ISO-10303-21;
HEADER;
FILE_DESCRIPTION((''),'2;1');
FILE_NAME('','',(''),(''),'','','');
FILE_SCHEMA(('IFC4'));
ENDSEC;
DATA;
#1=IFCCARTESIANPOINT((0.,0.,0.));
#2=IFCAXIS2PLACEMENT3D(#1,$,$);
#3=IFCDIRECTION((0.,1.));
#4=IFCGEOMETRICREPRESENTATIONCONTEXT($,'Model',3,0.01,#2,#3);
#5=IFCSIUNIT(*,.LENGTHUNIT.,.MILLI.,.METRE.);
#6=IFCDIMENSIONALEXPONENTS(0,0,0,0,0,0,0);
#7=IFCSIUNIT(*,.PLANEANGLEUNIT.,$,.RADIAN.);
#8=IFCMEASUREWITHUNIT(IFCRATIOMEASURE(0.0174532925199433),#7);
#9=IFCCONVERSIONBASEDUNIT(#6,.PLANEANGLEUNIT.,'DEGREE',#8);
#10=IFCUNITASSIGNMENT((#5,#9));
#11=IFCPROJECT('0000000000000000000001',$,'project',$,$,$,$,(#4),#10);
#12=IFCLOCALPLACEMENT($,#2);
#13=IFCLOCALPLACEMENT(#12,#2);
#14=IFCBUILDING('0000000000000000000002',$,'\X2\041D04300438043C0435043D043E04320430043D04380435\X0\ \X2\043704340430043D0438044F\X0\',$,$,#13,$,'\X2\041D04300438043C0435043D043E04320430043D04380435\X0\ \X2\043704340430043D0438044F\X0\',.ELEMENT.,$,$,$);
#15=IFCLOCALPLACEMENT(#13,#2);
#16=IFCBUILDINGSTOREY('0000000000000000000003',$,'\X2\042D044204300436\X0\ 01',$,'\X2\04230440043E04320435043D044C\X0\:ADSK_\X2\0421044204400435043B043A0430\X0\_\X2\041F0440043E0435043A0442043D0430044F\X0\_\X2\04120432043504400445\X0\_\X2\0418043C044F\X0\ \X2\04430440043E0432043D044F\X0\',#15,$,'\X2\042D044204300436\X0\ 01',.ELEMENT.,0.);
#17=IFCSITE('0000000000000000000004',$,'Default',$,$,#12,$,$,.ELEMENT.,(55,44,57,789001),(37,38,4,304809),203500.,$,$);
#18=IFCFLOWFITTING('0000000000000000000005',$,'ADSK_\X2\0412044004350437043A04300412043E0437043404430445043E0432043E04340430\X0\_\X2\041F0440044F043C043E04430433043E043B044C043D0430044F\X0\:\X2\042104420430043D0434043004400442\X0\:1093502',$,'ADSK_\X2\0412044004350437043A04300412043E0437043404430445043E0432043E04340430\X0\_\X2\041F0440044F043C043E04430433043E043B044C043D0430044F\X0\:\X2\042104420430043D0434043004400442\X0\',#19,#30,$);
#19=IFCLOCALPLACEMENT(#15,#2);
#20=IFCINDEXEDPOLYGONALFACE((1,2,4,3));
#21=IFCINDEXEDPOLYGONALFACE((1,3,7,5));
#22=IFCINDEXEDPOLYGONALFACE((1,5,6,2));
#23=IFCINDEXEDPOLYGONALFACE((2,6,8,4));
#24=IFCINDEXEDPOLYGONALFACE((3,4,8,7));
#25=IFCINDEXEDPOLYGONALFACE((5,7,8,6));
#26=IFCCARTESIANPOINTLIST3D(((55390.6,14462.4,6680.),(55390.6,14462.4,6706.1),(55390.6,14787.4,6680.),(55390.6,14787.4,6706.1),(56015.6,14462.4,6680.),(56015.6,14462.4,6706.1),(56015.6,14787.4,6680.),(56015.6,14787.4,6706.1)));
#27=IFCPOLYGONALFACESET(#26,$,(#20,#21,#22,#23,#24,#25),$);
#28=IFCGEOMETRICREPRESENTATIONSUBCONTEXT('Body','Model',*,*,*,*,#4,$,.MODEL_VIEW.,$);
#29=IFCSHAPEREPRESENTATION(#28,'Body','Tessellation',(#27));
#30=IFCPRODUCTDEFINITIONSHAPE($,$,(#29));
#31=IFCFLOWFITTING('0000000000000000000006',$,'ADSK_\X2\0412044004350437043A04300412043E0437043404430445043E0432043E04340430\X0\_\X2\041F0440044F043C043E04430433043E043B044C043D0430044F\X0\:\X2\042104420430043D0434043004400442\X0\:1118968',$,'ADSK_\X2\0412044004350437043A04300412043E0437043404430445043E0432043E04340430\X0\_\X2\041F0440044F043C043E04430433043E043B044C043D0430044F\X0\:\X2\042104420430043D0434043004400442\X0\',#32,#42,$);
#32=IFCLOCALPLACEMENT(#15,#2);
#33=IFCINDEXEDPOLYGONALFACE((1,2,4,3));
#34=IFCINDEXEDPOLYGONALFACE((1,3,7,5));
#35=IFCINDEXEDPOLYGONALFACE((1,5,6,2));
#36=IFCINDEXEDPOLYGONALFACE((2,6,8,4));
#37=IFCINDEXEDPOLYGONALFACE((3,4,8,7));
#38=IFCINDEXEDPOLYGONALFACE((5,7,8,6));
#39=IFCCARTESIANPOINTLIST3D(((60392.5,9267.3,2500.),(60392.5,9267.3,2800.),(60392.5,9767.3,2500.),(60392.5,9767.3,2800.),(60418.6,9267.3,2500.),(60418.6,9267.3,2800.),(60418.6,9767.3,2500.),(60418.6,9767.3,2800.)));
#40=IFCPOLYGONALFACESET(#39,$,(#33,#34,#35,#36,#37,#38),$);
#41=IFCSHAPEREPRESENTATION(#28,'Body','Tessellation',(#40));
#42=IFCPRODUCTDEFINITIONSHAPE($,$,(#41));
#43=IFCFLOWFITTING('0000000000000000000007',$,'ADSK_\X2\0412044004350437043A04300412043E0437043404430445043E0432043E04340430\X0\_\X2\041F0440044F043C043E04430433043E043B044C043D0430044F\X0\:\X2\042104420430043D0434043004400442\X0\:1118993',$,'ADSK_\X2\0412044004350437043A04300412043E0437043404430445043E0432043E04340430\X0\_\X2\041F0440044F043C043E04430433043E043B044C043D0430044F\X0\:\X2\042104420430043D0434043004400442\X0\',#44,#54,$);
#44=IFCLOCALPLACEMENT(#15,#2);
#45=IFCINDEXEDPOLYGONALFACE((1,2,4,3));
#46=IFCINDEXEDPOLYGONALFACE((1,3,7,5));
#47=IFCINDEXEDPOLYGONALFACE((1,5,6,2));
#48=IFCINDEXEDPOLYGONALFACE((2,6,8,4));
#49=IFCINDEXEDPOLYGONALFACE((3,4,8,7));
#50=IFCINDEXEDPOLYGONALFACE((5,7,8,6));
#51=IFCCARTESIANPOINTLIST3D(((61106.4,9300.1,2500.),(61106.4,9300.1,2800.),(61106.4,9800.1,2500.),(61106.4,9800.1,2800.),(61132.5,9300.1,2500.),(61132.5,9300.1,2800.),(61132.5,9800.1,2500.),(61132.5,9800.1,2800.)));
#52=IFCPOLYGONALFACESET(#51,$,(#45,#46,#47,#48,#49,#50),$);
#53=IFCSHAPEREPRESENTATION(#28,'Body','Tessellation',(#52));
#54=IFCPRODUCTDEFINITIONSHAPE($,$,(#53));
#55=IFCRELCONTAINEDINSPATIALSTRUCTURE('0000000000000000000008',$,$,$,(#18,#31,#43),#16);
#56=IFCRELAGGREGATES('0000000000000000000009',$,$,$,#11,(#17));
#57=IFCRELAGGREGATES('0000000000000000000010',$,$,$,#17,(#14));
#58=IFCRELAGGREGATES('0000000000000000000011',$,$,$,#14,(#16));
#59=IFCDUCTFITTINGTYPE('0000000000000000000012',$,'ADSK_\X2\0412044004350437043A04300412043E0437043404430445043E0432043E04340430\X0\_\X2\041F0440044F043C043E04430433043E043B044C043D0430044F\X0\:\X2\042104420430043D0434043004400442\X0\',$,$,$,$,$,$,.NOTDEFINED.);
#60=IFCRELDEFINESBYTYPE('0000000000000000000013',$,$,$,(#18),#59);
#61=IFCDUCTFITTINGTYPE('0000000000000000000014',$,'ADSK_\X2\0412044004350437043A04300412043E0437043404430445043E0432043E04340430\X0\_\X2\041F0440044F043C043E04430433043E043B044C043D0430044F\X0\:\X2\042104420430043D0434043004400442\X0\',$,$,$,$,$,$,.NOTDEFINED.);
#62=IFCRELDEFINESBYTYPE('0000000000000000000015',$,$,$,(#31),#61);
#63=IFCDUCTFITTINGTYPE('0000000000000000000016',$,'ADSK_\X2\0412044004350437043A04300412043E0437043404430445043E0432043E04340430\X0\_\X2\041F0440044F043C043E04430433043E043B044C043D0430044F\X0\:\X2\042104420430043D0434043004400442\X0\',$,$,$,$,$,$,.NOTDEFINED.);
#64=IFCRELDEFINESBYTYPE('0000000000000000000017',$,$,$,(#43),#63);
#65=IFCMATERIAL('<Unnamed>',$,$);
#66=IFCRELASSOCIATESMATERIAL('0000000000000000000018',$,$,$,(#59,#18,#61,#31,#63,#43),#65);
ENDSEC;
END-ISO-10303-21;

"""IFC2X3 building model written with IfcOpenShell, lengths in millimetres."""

from ifc_helpers import new_model, entity, si_unit, converted_unit, direction, frame, origin, origin_2d_with_axis, place, context, subcontext, project, spatial, rectangle, extrude, source, transform, mapped, material, type_object, type_shapes, element, save


model = new_model("IFC2X3")

# Units and contexts
model_context = context("Model", 3, precision=0.01, world=origin(), true_north=direction((0.0, 1.0)))
body_context = subcontext(model_context, "Body", "Model", "MODEL_VIEW")
ifc_project = project(units=[si_unit("LENGTHUNIT", "METRE", prefix="MILLI"), converted_unit("PLANEANGLEUNIT", "DEGREE", entity("IfcRatioMeasure", 0.0174532925199433), si_unit("PLANEANGLEUNIT", "RADIAN"), dimensions=[0, 0, 0, 0, 0, 0, 0])], contexts=[model_context])

# Site, building, storey
site_placement = place(None, origin())
site = spatial("IfcSite", under=ifc_project, at=site_placement, Name="Default", CompositionType="ELEMENT", RefLatitude=(55, 44, 57, 789001), RefLongitude=(37, 38, 4, 304809), RefElevation=203500.0)
building_placement = place(site_placement, origin())
building = spatial("IfcBuilding", under=site, at=building_placement, Name="Наименование здания", LongName="Наименование здания", CompositionType="ELEMENT")
storey_placement = place(building_placement, origin())
storey = spatial("IfcBuildingStorey", under=building, at=storey_placement, Name="Этаж 01", ObjectType="Уровень:ADSK_Стрелка_Проектная_Вверх_Имя уровня", LongName="Этаж 01", CompositionType="ELEMENT", Elevation=0.0)

# Shared definitions
ifc_material_1 = material(Name="<Unnamed>")

# Flow fittings
duct_fitting_type_1 = type_object("IfcDuctFittingType", Name="ADSK_ВрезкаВоздуховода_Прямоугольная:Стандарт", PredefinedType="NOTDEFINED", material=ifc_material_1)
shared_shape_1 = source(origin(), body_context, "Body", "SweptSolid", [
    extrude(rectangle(XDim=625.0, YDim=26.1, at=origin_2d_with_axis()), frame((7.0, 0.0, -162.5), z_axis=(0.0, 0.0, 1.0), x_axis=(0.0, -1.0, 0.0)), (0.0, 0.0, 1.0), 325.0),
])
type_shapes(duct_fitting_type_1, [shared_shape_1])
flow_fitting_1_placement = place(storey_placement, frame((55703.1, 14624.9, 6700.0), z_axis=(0.0, -1.0, 0.0), x_axis=(0.0, 0.0, -1.0)))
element("IfcFlowFitting", 1, at=flow_fitting_1_placement, inside=storey, type_object=duct_fitting_type_1, material=ifc_material_1, Name="ADSK_ВрезкаВоздуховода_Прямоугольная:Стандарт:1093502", ObjectType="ADSK_ВрезкаВоздуховода_Прямоугольная:Стандарт", context=body_context, shape_type="MappedRepresentation", body=[
    mapped(shared_shape_1, transform((0.0, 0.0, 0.0), scale=1.0)),
])
duct_fitting_type_2 = type_object("IfcDuctFittingType", Name="ADSK_ВрезкаВоздуховода_Прямоугольная:Стандарт", PredefinedType="NOTDEFINED", material=ifc_material_1)
shared_shape_2 = source(origin(), body_context, "Body", "SweptSolid", [
    extrude(rectangle(XDim=26.1, YDim=500.0, at=origin_2d_with_axis()), frame((7.0, 0.0, -150.0)), (0.0, 0.0, 1.0), 300.0),
])
type_shapes(duct_fitting_type_2, [shared_shape_2])
flow_fitting_2_placement = place(storey_placement, frame((60412.5, 9517.3, 2650.0), z_axis=(0.0, 0.0, -1.0), x_axis=(-1.0, 0.0, 0.0)))
element("IfcFlowFitting", 2, at=flow_fitting_2_placement, inside=storey, type_object=duct_fitting_type_2, material=ifc_material_1, Name="ADSK_ВрезкаВоздуховода_Прямоугольная:Стандарт:1118968", ObjectType="ADSK_ВрезкаВоздуховода_Прямоугольная:Стандарт", context=body_context, shape_type="MappedRepresentation", body=[
    mapped(shared_shape_2, transform((0.0, 0.0, 0.0), scale=1.0)),
])
duct_fitting_type_3 = type_object("IfcDuctFittingType", Name="ADSK_ВрезкаВоздуховода_Прямоугольная:Стандарт", PredefinedType="NOTDEFINED", material=ifc_material_1)
shared_shape_3 = source(origin(), body_context, "Body", "SweptSolid", [
    extrude(rectangle(XDim=500.0, YDim=26.1, at=origin_2d_with_axis()), frame((7.0, 0.0, -150.0), z_axis=(0.0, 0.0, 1.0), x_axis=(0.0, -1.0, 0.0)), (0.0, 0.0, 1.0), 300.0),
])
type_shapes(duct_fitting_type_3, [shared_shape_3])
flow_fitting_3_placement = place(storey_placement, frame((61112.5, 9550.1, 2650.0), z_axis=(0.0, 0.0, -1.0), x_axis=(1.0, 0.0, 0.0)))
element("IfcFlowFitting", 3, at=flow_fitting_3_placement, inside=storey, type_object=duct_fitting_type_3, material=ifc_material_1, Name="ADSK_ВрезкаВоздуховода_Прямоугольная:Стандарт:1118993", ObjectType="ADSK_ВрезкаВоздуховода_Прямоугольная:Стандарт", context=body_context, shape_type="MappedRepresentation", body=[
    mapped(shared_shape_3, transform((0.0, 0.0, 0.0), scale=1.0)),
])

save(model, "model.ifc")
